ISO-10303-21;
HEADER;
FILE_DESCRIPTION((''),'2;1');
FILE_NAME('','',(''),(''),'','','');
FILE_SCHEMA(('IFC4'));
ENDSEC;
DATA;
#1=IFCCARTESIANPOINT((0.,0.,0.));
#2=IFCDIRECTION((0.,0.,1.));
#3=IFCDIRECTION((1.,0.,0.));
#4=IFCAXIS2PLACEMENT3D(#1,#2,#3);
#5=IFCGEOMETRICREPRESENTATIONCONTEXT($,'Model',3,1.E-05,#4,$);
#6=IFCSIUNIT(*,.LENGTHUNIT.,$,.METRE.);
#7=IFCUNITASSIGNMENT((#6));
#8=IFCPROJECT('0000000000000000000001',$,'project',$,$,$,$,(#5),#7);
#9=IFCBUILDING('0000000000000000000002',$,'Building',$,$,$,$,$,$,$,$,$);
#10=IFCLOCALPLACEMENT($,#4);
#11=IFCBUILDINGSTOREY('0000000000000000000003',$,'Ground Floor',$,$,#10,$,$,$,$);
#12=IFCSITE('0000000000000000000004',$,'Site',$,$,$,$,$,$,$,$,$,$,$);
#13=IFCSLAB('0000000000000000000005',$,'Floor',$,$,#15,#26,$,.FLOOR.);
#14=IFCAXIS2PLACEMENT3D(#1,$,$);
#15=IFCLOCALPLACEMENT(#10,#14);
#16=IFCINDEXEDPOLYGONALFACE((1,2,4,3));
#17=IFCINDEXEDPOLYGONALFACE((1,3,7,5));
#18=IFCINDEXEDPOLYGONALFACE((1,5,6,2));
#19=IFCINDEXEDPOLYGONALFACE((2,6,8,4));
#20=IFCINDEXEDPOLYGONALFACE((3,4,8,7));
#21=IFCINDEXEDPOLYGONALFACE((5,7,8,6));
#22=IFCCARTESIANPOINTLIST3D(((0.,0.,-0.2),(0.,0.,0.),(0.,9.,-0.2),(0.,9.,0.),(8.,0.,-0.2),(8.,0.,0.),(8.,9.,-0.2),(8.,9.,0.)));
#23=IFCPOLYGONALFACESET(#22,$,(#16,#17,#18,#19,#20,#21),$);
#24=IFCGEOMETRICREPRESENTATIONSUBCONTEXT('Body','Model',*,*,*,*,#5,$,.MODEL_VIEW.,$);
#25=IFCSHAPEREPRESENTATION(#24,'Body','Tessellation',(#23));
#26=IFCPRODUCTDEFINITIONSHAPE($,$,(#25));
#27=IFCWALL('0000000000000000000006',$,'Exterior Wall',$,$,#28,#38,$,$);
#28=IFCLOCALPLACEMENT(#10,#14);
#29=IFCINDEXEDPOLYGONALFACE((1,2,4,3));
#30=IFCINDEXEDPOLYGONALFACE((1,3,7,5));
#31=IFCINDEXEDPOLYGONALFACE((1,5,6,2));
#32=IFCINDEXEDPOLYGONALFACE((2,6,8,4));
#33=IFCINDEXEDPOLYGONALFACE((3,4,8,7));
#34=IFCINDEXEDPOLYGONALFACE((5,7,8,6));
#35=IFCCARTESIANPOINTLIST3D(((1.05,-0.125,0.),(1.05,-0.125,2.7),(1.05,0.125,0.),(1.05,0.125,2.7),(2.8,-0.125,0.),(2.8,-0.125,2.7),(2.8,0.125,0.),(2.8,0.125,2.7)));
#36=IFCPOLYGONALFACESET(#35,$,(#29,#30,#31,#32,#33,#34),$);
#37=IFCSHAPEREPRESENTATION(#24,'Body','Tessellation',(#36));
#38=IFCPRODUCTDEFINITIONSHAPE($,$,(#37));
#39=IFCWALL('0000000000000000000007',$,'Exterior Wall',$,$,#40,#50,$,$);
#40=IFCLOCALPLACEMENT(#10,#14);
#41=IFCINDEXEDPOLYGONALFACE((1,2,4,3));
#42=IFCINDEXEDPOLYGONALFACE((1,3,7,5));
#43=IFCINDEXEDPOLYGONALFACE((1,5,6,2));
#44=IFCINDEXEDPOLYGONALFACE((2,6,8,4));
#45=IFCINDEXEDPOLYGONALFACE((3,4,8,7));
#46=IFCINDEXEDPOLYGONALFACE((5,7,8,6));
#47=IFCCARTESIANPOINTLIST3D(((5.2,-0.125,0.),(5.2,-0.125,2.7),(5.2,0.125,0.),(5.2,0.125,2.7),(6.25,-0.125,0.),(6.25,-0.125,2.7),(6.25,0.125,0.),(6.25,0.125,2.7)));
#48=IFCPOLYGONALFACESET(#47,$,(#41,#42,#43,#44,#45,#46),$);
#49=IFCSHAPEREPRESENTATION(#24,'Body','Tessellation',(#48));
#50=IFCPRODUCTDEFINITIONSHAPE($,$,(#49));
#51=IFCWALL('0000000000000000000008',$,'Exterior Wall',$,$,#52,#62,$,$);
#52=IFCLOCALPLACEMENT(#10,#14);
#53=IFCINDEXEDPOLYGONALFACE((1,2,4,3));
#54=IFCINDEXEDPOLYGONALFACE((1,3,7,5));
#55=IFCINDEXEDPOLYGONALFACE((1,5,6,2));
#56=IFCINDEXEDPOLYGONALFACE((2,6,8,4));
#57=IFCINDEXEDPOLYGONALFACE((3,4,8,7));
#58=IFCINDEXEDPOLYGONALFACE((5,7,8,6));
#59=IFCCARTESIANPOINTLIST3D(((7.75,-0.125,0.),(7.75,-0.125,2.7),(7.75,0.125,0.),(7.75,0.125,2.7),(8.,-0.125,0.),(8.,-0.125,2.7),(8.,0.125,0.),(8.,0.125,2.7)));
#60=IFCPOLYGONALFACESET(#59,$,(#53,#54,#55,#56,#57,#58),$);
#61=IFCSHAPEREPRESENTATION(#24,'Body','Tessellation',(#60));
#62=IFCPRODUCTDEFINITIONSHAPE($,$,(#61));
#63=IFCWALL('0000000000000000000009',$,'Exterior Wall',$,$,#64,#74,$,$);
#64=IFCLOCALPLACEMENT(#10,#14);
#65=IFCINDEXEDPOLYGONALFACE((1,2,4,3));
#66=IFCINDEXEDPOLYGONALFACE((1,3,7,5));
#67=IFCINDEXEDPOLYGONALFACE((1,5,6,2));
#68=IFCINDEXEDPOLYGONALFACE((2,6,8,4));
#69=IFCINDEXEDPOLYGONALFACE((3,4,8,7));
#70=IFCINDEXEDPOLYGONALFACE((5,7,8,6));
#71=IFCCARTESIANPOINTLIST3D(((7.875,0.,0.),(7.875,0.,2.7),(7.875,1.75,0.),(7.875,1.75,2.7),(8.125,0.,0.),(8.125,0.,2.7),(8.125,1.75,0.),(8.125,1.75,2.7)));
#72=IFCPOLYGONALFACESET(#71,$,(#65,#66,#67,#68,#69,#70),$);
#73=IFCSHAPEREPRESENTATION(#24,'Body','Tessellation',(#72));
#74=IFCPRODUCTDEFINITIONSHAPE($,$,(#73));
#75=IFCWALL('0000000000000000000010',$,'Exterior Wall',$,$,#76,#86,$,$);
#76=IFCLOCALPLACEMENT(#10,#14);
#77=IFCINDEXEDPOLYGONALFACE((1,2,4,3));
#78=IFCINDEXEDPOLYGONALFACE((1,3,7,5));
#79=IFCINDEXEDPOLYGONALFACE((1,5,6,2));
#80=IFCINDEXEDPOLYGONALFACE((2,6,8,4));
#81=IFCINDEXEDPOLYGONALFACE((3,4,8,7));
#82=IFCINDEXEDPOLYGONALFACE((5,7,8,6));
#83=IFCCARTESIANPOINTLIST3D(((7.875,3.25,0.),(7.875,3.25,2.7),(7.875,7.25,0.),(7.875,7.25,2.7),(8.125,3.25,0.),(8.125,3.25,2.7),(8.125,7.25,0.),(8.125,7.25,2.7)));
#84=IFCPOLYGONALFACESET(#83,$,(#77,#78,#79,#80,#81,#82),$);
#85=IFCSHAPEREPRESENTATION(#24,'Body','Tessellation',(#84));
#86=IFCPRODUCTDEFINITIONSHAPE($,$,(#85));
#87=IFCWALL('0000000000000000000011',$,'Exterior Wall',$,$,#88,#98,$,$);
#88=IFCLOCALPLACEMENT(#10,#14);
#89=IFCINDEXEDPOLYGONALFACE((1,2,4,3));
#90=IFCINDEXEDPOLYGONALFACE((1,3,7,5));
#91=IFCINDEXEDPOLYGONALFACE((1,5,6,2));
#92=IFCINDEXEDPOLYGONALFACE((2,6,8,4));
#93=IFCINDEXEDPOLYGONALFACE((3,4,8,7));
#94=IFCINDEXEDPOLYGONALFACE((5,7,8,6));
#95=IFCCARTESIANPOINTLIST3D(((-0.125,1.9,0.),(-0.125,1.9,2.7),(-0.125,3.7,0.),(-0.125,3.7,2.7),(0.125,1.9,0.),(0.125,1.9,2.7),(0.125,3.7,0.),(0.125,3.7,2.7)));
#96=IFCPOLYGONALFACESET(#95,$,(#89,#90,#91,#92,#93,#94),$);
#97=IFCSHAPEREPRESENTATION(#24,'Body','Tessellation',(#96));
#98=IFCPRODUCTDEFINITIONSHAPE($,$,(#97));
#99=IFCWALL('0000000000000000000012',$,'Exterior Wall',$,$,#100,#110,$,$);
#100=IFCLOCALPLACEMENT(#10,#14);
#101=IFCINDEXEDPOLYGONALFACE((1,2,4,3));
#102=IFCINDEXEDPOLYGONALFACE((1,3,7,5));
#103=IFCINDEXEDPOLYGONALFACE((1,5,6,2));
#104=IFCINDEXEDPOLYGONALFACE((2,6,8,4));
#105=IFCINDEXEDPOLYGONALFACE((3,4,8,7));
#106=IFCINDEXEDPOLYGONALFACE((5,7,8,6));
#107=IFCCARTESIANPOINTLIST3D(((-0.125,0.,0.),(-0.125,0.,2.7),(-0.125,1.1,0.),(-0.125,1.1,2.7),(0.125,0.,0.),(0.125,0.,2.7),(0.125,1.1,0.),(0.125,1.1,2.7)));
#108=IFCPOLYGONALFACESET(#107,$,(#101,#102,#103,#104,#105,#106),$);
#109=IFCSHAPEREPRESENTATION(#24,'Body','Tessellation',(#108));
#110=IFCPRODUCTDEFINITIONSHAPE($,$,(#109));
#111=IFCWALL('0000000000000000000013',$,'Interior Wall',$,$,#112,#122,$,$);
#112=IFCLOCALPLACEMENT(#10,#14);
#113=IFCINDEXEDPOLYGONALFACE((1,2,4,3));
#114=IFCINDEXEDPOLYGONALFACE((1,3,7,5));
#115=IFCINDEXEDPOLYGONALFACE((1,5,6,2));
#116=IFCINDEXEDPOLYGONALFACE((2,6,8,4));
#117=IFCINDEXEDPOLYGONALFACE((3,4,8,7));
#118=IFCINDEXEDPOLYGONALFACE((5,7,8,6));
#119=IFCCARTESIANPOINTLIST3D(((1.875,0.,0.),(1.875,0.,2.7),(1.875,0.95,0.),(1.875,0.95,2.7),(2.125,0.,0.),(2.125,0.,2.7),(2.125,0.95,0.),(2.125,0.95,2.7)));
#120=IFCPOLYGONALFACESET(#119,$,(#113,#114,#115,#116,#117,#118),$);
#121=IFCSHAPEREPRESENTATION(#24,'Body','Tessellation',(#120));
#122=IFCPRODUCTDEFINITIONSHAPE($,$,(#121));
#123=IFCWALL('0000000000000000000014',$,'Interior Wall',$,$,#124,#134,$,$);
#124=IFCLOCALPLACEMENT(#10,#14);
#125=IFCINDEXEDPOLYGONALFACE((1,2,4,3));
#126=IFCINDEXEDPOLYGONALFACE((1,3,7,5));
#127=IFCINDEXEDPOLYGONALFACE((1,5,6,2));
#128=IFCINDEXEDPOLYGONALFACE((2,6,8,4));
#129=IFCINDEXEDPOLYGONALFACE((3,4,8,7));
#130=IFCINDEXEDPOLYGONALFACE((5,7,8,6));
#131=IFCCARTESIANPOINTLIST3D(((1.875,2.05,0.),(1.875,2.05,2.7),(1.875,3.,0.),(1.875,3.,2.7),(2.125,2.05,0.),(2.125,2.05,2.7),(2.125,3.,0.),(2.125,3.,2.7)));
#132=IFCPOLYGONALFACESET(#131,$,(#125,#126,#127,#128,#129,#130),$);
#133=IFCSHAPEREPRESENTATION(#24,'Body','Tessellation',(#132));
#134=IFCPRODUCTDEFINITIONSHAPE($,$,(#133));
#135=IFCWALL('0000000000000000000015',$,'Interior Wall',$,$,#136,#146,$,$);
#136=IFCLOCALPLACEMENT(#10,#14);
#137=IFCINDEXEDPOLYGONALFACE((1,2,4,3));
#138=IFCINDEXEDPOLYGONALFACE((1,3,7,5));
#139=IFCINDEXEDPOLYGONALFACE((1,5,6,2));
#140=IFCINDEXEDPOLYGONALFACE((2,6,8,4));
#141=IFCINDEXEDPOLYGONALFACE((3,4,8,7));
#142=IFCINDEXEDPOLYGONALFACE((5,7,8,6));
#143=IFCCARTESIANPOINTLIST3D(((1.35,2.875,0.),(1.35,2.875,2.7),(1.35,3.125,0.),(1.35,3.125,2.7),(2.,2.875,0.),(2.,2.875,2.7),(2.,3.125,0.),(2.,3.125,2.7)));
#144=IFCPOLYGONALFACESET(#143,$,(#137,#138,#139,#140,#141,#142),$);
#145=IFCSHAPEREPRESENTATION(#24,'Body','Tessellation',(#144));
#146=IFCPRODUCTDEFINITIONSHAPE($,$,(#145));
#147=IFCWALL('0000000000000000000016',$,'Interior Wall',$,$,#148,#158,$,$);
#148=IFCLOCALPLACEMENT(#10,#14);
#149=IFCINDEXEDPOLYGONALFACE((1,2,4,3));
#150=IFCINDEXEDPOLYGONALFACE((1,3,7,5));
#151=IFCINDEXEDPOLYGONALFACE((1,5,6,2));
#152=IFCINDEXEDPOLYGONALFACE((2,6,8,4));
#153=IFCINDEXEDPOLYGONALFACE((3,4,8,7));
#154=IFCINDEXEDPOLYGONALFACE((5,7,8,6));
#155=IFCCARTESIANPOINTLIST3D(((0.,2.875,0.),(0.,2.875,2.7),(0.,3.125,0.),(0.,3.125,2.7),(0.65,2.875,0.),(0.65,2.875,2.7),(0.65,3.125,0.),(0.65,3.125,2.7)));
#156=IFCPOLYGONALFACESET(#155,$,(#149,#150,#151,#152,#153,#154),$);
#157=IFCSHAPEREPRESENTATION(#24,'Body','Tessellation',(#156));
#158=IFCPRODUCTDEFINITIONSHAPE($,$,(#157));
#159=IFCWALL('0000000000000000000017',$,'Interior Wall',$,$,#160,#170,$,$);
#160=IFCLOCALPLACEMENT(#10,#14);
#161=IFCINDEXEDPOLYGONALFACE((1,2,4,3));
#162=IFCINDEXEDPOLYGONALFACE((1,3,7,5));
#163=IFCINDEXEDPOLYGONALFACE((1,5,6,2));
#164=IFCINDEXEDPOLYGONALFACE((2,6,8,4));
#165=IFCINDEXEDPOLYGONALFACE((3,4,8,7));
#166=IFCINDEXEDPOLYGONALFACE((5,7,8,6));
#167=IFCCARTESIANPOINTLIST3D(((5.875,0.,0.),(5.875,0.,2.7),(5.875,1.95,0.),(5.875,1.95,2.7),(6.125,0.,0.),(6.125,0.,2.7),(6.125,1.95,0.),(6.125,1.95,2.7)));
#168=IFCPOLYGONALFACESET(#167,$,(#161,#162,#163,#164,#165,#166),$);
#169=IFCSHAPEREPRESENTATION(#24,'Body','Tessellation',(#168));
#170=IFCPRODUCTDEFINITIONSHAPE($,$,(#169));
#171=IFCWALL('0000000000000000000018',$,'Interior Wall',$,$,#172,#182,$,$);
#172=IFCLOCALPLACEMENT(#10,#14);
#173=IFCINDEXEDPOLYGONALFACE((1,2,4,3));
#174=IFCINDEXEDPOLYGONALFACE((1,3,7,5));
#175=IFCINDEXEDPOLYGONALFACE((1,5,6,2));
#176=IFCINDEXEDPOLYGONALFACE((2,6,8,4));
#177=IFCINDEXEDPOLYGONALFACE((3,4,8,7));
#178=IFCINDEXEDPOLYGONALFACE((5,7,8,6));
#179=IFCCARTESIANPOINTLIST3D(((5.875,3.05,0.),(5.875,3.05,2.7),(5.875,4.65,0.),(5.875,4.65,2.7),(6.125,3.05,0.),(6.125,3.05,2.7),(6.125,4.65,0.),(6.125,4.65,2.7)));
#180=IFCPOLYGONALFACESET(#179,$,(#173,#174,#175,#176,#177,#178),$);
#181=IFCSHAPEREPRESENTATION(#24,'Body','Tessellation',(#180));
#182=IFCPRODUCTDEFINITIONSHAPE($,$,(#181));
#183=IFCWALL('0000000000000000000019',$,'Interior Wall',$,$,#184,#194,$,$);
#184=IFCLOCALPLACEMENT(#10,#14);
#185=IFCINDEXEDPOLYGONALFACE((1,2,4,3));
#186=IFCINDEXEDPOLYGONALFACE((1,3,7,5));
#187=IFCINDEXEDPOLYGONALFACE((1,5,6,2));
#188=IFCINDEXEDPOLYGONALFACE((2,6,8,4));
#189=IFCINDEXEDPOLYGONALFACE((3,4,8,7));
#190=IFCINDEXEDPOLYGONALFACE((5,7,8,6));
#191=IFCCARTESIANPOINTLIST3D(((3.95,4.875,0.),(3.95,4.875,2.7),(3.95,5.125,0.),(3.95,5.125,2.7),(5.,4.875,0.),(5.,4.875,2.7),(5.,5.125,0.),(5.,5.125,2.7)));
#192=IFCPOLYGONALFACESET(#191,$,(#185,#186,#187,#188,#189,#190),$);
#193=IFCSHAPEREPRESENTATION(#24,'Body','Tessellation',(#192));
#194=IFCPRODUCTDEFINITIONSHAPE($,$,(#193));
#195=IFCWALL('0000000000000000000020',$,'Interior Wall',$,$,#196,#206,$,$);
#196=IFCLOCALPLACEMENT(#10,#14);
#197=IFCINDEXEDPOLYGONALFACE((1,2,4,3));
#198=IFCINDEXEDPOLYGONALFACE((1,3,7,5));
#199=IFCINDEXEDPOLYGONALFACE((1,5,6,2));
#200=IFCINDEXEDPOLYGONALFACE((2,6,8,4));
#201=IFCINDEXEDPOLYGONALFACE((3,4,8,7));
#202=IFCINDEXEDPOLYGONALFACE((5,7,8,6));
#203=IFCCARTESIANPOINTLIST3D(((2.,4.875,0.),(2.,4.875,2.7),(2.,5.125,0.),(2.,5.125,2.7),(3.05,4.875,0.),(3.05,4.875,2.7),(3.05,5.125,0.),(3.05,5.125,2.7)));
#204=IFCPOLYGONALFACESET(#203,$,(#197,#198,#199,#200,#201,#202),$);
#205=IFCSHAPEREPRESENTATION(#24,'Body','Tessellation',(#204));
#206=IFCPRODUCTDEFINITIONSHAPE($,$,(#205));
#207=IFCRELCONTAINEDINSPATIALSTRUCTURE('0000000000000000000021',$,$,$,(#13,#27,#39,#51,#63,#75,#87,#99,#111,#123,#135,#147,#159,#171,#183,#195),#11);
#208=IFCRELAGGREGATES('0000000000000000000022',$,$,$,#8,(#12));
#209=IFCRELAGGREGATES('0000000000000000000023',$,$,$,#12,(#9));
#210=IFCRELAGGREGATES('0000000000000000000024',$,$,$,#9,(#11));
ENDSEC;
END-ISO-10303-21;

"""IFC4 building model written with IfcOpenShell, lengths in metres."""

from ifc_helpers import new_model, si_unit, frame, origin_with_axes, place, context, subcontext, project, spatial, indexed_curve, outline, extrude, element, save


model = new_model("IFC4")

# Units and contexts
model_context = context("Model", 3, precision=1e-05, world=origin_with_axes())
body_context = subcontext(model_context, "Body", "Model", "MODEL_VIEW")
ifc_project = project(units=[si_unit("LENGTHUNIT", "METRE")], contexts=[model_context])

# Site, building, storey
site = spatial("IfcSite", under=ifc_project, Name="Site")
building = spatial("IfcBuilding", under=site, Name="Building")
storey_placement = place(None, origin_with_axes())
storey = spatial("IfcBuildingStorey", under=building, at=storey_placement, Name="Ground Floor")

# Slab
slab_placement = place(storey_placement, frame((0.0, 0.0, -0.2), z_axis=(0.0, 0.0, 1.0), x_axis=(1.0, 0.0, 0.0)))
element("IfcSlab", 1, at=slab_placement, inside=storey, Name="Floor", PredefinedType="FLOOR", context=body_context, shape_type="SweptSolid", body=[
    extrude(outline(indexed_curve([(0.0, 0.0), (8.0, 0.0), (8.0, 9.0), (0.0, 9.0)])), None, (0.0, 0.0, 1.0), 0.2),
])

# Walls
wall_1_placement = place(storey_placement, frame((1.05, 0.0, 0.0), z_axis=(0.0, 0.0, 1.0), x_axis=(1.0, 0.0, 0.0)))
element("IfcWall", 2, at=wall_1_placement, inside=storey, Name="Exterior Wall", context=body_context, shape_type="SweptSolid", body=[
    extrude(outline(indexed_curve([(0.0, 0.0), (0.0, 0.25), (1.75, 0.25), (1.75, 0.0), (0.0, 0.0)], self_intersect=False)), frame((0.0, -0.125, 0.0), z_axis=(0.0, 0.0, 1.0), x_axis=(1.0, 0.0, 0.0)), (0.0, 0.0, 1.0), 2.7),
])
wall_2_placement = place(storey_placement, frame((5.2, 0.0, 0.0), z_axis=(0.0, 0.0, 1.0), x_axis=(1.0, 0.0, 0.0)))
element("IfcWall", 3, at=wall_2_placement, inside=storey, Name="Exterior Wall", context=body_context, shape_type="SweptSolid", body=[
    extrude(outline(indexed_curve([(0.0, 0.0), (0.0, 0.25), (1.05, 0.25), (1.05, 0.0), (0.0, 0.0)], self_intersect=False)), frame((0.0, -0.125, 0.0), z_axis=(0.0, 0.0, 1.0), x_axis=(1.0, 0.0, 0.0)), (0.0, 0.0, 1.0), 2.7),
])
wall_3_placement = place(storey_placement, frame((7.75, 0.0, 0.0), z_axis=(0.0, 0.0, 1.0), x_axis=(1.0, 0.0, 0.0)))
element("IfcWall", 4, at=wall_3_placement, inside=storey, Name="Exterior Wall", context=body_context, shape_type="SweptSolid", body=[
    extrude(outline(indexed_curve([(0.0, 0.0), (0.0, 0.25), (0.25, 0.25), (0.25, 0.0), (0.0, 0.0)], self_intersect=False)), frame((0.0, -0.125, 0.0), z_axis=(0.0, 0.0, 1.0), x_axis=(1.0, 0.0, 0.0)), (0.0, 0.0, 1.0), 2.7),
])
wall_4_placement = place(storey_placement, frame((8.0, 0.0, 0.0), z_axis=(0.0, 0.0, 1.0), x_axis=(0.0, 1.0, 0.0)))
element("IfcWall", 5, at=wall_4_placement, inside=storey, Name="Exterior Wall", context=body_context, shape_type="SweptSolid", body=[
    extrude(outline(indexed_curve([(0.0, 0.0), (0.0, 0.25), (1.75, 0.25), (1.75, 0.0), (0.0, 0.0)], self_intersect=False)), frame((0.0, -0.125, 0.0), z_axis=(0.0, 0.0, 1.0), x_axis=(1.0, 0.0, 0.0)), (0.0, 0.0, 1.0), 2.7),
])
wall_5_placement = place(storey_placement, frame((8.0, 3.25, 0.0), z_axis=(0.0, 0.0, 1.0), x_axis=(0.0, 1.0, 0.0)))
element("IfcWall", 6, at=wall_5_placement, inside=storey, Name="Exterior Wall", context=body_context, shape_type="SweptSolid", body=[
    extrude(outline(indexed_curve([(0.0, 0.0), (0.0, 0.25), (4.0, 0.25), (4.0, 0.0), (0.0, 0.0)], self_intersect=False)), frame((0.0, -0.125, 0.0), z_axis=(0.0, 0.0, 1.0), x_axis=(1.0, 0.0, 0.0)), (0.0, 0.0, 1.0), 2.7),
])
wall_6_placement = place(storey_placement, frame((0.0, 3.7, 0.0), z_axis=(0.0, 0.0, 1.0), x_axis=(0.0, -1.0, 0.0)))
element("IfcWall", 7, at=wall_6_placement, inside=storey, Name="Exterior Wall", context=body_context, shape_type="SweptSolid", body=[
    extrude(outline(indexed_curve([(0.0, 0.0), (0.0, 0.25), (1.8, 0.25), (1.8, 0.0), (0.0, 0.0)], self_intersect=False)), frame((0.0, -0.125, 0.0), z_axis=(0.0, 0.0, 1.0), x_axis=(1.0, 0.0, 0.0)), (0.0, 0.0, 1.0), 2.7),
])
wall_7_placement = place(storey_placement, frame((0.0, 1.1, 0.0), z_axis=(0.0, 0.0, 1.0), x_axis=(0.0, -1.0, 0.0)))
element("IfcWall", 8, at=wall_7_placement, inside=storey, Name="Exterior Wall", context=body_context, shape_type="SweptSolid", body=[
    extrude(outline(indexed_curve([(0.0, 0.0), (0.0, 0.25), (1.1, 0.25), (1.1, 0.0), (0.0, 0.0)], self_intersect=False)), frame((0.0, -0.125, 0.0), z_axis=(0.0, 0.0, 1.0), x_axis=(1.0, 0.0, 0.0)), (0.0, 0.0, 1.0), 2.7),
])
wall_8_placement = place(storey_placement, frame((2.0, 0.0, 0.0), z_axis=(0.0, 0.0, 1.0), x_axis=(0.0, 1.0, 0.0)))
element("IfcWall", 9, at=wall_8_placement, inside=storey, Name="Interior Wall", context=body_context, shape_type="SweptSolid", body=[
    extrude(outline(indexed_curve([(0.0, 0.0), (0.0, 0.25), (0.95, 0.25), (0.95, 0.0), (0.0, 0.0)], self_intersect=False)), frame((0.0, -0.125, 0.0), z_axis=(0.0, 0.0, 1.0), x_axis=(1.0, 0.0, 0.0)), (0.0, 0.0, 1.0), 2.7),
])
wall_9_placement = place(storey_placement, frame((2.0, 2.05, 0.0), z_axis=(0.0, 0.0, 1.0), x_axis=(0.0, 1.0, 0.0)))
element("IfcWall", 10, at=wall_9_placement, inside=storey, Name="Interior Wall", context=body_context, shape_type="SweptSolid", body=[
    extrude(outline(indexed_curve([(0.0, 0.0), (0.0, 0.25), (0.95, 0.25), (0.95, 0.0), (0.0, 0.0)], self_intersect=False)), frame((0.0, -0.125, 0.0), z_axis=(0.0, 0.0, 1.0), x_axis=(1.0, 0.0, 0.0)), (0.0, 0.0, 1.0), 2.7),
])
for number, where, z_axis, x_axis, name in (
    (11, (2.0, 3.0, 0.0), (0.0, 0.0, 1.0), (-1.0, 0.0, 0.0), "Interior Wall"),
    (12, (0.65, 3.0, 0.0), (0.0, 0.0, 1.0), (-1.0, 0.0, 0.0), "Interior Wall"),
):
    element("IfcWall", number, at=place(storey_placement, frame(where, z_axis=z_axis, x_axis=x_axis)), inside=storey, Name=name, context=body_context, shape_type="SweptSolid", body=[
        extrude(outline(indexed_curve([(0.0, 0.0), (0.0, 0.25), (0.65, 0.25), (0.65, 0.0), (0.0, 0.0)], self_intersect=False)), frame((0.0, -0.125, 0.0), z_axis=(0.0, 0.0, 1.0), x_axis=(1.0, 0.0, 0.0)), (0.0, 0.0, 1.0), 2.7),
    ])
wall_10_placement = place(storey_placement, frame((6.0, 0.0, 0.0), z_axis=(0.0, 0.0, 1.0), x_axis=(0.0, 1.0, 0.0)))
element("IfcWall", 13, at=wall_10_placement, inside=storey, Name="Interior Wall", context=body_context, shape_type="SweptSolid", body=[
    extrude(outline(indexed_curve([(0.0, 0.0), (0.0, 0.25), (1.95, 0.25), (1.95, 0.0), (0.0, 0.0)], self_intersect=False)), frame((0.0, -0.125, 0.0), z_axis=(0.0, 0.0, 1.0), x_axis=(1.0, 0.0, 0.0)), (0.0, 0.0, 1.0), 2.7),
])
wall_11_placement = place(storey_placement, frame((6.0, 3.05, 0.0), z_axis=(0.0, 0.0, 1.0), x_axis=(0.0, 1.0, 0.0)))
element("IfcWall", 14, at=wall_11_placement, inside=storey, Name="Interior Wall", context=body_context, shape_type="SweptSolid", body=[
    extrude(outline(indexed_curve([(0.0, 0.0), (0.0, 0.25), (1.6, 0.25), (1.6, 0.0), (0.0, 0.0)], self_intersect=False)), frame((0.0, -0.125, 0.0), z_axis=(0.0, 0.0, 1.0), x_axis=(1.0, 0.0, 0.0)), (0.0, 0.0, 1.0), 2.7),
])
for number, where, z_axis, x_axis, name in (
    (15, (5.0, 5.0, 0.0), (0.0, 0.0, 1.0), (-1.0, 0.0, 0.0), "Interior Wall"),
    (16, (3.05, 5.0, 0.0), (0.0, 0.0, 1.0), (-1.0, 0.0, 0.0), "Interior Wall"),
):
    element("IfcWall", number, at=place(storey_placement, frame(where, z_axis=z_axis, x_axis=x_axis)), inside=storey, Name=name, context=body_context, shape_type="SweptSolid", body=[
        extrude(outline(indexed_curve([(0.0, 0.0), (0.0, 0.25), (1.05, 0.25), (1.05, 0.0), (0.0, 0.0)], self_intersect=False)), frame((0.0, -0.125, 0.0), z_axis=(0.0, 0.0, 1.0), x_axis=(1.0, 0.0, 0.0)), (0.0, 0.0, 1.0), 2.7),
    ])

save(model, "model.ifc")
